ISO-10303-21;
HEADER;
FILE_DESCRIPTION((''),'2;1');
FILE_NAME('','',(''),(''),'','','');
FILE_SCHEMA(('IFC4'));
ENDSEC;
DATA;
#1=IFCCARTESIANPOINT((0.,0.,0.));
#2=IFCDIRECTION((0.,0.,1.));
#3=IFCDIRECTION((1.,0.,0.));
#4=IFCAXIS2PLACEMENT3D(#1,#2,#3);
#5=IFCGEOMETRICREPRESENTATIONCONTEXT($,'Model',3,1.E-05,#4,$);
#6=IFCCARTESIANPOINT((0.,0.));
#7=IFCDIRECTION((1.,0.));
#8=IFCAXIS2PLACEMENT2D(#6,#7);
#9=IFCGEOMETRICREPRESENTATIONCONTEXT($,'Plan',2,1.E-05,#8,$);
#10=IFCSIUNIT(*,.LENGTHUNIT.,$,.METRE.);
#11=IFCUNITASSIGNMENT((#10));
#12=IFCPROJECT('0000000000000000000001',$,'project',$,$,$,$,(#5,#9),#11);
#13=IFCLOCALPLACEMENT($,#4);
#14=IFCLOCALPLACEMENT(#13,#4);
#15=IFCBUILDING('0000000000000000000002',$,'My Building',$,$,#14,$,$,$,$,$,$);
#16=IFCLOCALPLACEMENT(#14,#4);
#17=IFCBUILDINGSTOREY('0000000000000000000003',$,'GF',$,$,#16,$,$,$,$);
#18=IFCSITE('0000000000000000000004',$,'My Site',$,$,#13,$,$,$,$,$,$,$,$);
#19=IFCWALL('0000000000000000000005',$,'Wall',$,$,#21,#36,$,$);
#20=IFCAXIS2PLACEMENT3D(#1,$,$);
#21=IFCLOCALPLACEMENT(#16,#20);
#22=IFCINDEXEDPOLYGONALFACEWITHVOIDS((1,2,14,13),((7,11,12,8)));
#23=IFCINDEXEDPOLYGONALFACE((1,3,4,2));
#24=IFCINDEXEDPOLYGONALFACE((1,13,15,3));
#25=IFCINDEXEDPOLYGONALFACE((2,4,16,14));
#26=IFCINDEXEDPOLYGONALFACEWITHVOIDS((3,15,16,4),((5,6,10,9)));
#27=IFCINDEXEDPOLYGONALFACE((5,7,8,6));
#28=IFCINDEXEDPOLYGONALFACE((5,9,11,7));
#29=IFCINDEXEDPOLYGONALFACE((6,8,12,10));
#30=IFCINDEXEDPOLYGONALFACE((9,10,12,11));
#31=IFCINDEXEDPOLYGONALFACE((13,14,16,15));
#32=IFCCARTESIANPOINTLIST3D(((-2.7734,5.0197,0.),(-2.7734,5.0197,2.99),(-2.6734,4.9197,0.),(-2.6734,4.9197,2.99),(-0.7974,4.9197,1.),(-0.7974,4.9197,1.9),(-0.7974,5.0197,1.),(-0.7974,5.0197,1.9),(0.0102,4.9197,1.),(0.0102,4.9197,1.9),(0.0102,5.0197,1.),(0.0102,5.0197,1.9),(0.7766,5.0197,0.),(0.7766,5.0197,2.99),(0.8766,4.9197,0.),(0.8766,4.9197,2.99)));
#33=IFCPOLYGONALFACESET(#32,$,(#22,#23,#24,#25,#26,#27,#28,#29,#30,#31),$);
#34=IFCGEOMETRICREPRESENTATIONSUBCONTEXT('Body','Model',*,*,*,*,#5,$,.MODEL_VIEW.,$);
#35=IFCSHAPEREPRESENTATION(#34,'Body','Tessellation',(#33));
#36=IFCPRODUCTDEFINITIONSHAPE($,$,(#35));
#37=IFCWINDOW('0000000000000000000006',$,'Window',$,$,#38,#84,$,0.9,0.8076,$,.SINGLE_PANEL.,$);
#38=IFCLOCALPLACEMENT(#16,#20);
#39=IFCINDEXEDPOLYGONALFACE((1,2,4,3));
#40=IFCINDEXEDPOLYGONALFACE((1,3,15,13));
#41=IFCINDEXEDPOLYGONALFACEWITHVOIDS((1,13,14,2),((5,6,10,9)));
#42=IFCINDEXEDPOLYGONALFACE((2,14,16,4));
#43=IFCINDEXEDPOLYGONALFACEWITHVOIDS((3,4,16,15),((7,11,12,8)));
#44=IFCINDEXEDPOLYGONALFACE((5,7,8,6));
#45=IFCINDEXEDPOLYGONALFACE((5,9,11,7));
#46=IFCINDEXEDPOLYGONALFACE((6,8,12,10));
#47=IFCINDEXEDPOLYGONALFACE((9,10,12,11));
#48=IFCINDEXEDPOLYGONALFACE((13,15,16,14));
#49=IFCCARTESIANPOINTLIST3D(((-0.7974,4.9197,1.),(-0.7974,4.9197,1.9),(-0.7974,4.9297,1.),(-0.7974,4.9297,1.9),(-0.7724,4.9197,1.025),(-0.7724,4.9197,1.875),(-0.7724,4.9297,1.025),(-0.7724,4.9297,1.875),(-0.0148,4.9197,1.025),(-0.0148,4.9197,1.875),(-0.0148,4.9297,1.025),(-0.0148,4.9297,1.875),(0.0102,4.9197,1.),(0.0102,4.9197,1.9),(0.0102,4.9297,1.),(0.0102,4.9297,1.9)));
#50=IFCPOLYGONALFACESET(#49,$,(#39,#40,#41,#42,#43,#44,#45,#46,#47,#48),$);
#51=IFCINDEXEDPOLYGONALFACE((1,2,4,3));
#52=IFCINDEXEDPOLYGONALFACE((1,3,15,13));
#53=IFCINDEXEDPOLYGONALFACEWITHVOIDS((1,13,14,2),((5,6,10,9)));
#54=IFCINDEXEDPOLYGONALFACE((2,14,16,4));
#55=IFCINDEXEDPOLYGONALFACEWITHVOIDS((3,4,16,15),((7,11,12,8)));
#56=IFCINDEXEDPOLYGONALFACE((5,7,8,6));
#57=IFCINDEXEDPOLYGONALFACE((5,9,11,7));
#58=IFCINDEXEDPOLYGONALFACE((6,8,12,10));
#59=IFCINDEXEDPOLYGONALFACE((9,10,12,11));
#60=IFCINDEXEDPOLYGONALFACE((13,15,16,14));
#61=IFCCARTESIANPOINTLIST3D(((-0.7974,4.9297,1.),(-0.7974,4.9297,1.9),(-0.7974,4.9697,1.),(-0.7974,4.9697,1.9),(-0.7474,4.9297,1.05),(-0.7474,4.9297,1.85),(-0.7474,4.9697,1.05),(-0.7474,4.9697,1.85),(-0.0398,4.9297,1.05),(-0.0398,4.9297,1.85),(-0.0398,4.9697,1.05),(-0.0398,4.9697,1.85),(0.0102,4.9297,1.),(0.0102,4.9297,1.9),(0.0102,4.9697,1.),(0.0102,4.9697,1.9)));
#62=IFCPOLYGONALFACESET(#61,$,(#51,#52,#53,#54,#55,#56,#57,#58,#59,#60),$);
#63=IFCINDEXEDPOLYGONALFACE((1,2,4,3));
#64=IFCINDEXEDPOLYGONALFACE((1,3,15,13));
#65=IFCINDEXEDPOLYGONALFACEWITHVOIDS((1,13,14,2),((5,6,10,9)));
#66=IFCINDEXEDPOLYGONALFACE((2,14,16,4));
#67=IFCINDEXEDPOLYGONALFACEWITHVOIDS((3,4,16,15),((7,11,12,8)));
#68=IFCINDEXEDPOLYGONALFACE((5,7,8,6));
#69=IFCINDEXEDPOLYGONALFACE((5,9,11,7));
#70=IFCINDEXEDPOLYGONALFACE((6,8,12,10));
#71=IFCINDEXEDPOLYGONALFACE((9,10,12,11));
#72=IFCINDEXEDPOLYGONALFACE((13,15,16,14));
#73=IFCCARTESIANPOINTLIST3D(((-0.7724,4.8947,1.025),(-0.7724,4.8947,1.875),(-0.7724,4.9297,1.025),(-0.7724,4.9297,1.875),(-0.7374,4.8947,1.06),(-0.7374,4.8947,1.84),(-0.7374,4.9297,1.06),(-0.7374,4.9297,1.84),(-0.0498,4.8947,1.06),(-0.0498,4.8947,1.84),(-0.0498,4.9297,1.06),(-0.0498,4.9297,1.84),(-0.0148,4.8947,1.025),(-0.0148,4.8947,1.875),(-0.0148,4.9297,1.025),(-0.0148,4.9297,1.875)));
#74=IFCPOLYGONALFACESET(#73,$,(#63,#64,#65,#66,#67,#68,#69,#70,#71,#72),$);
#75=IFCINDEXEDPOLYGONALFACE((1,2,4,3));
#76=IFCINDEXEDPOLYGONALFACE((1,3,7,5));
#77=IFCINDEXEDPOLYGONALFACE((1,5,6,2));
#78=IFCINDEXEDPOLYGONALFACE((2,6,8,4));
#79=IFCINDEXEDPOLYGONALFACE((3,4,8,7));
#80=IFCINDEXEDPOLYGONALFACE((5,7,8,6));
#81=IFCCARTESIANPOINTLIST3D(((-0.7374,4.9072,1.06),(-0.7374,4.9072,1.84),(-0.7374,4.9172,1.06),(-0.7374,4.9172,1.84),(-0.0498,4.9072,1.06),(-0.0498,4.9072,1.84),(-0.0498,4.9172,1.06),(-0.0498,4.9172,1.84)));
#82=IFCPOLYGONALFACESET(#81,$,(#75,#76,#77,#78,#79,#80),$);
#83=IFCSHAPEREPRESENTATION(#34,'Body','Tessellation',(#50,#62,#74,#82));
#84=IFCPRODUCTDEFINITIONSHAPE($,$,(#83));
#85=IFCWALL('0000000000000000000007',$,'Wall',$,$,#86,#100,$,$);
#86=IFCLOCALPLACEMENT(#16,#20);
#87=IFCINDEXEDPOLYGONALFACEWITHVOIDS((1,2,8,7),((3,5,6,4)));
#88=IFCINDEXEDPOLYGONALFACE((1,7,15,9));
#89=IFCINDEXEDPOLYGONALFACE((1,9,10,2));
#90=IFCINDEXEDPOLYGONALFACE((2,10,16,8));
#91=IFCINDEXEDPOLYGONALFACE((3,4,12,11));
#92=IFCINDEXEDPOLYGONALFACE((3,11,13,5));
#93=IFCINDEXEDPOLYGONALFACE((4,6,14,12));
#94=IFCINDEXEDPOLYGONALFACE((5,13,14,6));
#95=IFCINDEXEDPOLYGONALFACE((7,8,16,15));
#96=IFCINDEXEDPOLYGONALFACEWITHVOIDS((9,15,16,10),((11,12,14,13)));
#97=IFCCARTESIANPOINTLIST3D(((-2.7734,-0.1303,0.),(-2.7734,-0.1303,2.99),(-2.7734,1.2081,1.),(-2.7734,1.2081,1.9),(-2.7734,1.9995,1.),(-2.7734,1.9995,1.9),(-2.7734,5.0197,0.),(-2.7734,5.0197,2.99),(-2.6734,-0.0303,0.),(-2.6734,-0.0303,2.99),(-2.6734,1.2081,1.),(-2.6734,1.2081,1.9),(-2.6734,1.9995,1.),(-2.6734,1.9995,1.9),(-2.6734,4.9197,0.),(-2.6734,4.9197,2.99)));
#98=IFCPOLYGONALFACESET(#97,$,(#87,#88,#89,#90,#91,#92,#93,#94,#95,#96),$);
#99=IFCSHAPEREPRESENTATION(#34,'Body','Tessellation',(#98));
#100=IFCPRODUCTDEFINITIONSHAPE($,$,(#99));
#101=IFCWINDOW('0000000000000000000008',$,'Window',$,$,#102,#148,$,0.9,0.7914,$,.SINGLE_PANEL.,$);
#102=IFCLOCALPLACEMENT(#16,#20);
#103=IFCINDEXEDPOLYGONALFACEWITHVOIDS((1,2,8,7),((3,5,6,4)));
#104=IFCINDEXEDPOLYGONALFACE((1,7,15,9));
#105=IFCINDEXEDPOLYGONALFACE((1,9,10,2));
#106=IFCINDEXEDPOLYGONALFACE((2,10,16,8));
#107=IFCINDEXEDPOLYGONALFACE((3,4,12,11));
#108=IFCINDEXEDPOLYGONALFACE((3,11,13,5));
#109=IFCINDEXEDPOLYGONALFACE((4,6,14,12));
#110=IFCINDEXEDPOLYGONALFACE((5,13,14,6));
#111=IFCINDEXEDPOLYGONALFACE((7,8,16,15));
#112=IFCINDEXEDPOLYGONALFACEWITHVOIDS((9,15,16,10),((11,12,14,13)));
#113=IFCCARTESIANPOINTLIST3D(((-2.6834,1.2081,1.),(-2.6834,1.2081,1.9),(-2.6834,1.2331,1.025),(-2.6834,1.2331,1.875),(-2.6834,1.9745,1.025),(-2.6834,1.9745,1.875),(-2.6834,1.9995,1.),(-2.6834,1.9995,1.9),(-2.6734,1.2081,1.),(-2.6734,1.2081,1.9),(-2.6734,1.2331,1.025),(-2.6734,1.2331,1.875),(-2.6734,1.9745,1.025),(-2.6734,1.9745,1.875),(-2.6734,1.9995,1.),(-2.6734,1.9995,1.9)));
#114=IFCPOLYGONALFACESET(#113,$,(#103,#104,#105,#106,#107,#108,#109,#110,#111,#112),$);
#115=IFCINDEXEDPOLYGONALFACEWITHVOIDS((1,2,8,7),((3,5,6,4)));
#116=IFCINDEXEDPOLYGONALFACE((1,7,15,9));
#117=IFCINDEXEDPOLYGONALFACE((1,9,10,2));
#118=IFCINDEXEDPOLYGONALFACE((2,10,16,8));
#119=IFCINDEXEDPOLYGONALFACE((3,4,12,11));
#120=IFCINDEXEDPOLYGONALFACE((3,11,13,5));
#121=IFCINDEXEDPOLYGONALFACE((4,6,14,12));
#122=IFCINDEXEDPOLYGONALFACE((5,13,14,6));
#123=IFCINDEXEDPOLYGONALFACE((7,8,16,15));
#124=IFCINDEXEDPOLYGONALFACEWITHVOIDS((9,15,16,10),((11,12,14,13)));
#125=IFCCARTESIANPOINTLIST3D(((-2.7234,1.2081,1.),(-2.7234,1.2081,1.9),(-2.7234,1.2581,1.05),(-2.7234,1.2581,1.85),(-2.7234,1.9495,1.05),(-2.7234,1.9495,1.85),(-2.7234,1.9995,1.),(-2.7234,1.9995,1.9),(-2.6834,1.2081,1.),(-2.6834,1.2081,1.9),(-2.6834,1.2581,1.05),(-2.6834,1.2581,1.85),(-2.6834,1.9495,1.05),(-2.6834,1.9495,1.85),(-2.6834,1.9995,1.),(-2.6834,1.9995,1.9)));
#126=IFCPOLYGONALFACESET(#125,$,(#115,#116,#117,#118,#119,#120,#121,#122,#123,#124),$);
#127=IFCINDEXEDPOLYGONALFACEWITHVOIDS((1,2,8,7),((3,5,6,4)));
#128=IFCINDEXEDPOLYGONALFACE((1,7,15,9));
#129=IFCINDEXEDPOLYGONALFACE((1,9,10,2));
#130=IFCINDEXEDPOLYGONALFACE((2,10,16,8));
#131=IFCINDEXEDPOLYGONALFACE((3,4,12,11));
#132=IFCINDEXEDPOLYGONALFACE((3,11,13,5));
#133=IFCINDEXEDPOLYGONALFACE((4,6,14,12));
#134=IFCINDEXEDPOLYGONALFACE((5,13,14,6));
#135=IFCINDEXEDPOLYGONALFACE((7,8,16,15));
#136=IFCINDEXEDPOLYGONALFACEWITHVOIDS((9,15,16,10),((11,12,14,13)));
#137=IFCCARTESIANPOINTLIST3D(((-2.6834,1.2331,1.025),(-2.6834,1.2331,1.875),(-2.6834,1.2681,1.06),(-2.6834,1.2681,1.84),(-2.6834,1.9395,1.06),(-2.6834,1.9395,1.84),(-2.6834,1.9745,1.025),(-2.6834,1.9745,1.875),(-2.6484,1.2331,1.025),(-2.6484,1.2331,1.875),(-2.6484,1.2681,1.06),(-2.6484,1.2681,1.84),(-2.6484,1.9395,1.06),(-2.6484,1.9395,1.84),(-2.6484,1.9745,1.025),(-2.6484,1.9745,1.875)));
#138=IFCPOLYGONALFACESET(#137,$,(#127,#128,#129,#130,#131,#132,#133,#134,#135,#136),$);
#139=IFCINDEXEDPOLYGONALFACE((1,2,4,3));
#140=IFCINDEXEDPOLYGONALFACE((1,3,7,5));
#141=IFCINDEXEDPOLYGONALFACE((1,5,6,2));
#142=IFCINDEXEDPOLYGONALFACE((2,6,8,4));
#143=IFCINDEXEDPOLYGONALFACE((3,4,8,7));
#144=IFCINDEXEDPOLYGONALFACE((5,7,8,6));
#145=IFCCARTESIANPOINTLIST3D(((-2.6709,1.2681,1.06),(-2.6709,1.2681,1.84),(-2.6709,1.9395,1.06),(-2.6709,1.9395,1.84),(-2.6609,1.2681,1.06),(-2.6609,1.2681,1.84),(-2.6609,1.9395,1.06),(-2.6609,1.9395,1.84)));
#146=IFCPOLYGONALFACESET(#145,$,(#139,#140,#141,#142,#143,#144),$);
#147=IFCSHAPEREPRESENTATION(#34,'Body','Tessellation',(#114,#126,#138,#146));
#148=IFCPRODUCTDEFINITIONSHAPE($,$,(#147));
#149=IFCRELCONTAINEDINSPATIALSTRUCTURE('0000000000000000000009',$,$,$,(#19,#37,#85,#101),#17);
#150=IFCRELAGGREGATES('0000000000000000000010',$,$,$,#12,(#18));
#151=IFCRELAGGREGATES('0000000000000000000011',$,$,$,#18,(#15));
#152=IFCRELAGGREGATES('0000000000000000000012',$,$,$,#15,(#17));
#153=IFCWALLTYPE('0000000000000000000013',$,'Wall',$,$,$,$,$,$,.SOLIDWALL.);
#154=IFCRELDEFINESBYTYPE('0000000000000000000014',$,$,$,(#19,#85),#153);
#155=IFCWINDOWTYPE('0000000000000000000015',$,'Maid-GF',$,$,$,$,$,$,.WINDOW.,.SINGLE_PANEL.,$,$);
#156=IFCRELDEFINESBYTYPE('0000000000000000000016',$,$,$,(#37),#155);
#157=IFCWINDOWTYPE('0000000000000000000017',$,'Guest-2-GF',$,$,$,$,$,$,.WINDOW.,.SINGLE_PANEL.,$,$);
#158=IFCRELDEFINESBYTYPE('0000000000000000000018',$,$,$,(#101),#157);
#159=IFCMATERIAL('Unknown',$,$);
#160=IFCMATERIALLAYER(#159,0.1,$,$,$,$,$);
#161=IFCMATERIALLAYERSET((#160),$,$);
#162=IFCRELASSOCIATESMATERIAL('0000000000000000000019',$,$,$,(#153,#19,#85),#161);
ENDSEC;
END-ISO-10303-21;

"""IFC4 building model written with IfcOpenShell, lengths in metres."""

from ifc_helpers import new_model, entity, si_unit, frame, origin_with_axes, origin_2d_with_axis, place, context, subcontext, project, spatial, line, indexed_curve, outline, extrude, shape, source, transform, mapped, material, layer, layer_set, layer_usage, type_object, type_shapes, element, fill, save


model = new_model("IFC4")

# Units and contexts
model_context = context("Model", 3, precision=1e-05, world=origin_with_axes())
plan_context = context("Plan", 2, precision=1e-05, world=origin_2d_with_axis())
body_context_1 = subcontext(model_context, "Body", "Model", "MODEL_VIEW")
body_context_2 = subcontext(plan_context, "Body", "Plan", "PLAN_VIEW")
ifc_project = project(units=[si_unit("LENGTHUNIT", "METRE")], contexts=[model_context, plan_context])

# Site, building, storey
site_placement = place(None, origin_with_axes())
site = spatial("IfcSite", under=ifc_project, at=site_placement, Name="My Site")
building_placement = place(site_placement, origin_with_axes())
building = spatial("IfcBuilding", under=site, at=building_placement, Name="My Building")
storey_placement = place(building_placement, origin_with_axes())
storey = spatial("IfcBuildingStorey", under=building, at=storey_placement, Name="GF")

# Shared definitions
ifc_material_1 = material(Name="Unknown")

# Shared definitions
ifc_layer_1 = layer(ifc_material_1, 0.1)
ifc_layer_set_1 = layer_set([ifc_layer_1])
wall_type = type_object("IfcWallType", Name="Wall", PredefinedType="SOLIDWALL", material=ifc_layer_set_1)

# Walls, openings, windows
ifc_layer_usage_1 = layer_usage(ifc_layer_set_1, "AXIS2", "POSITIVE", 0.0)
wall_1_placement = place(storey_placement, frame((0.7766, 5.0197, 0.0), z_axis=(0.0, 0.0, 1.0), x_axis=(-1.0, 0.0, 0.0)))
wall_1 = element("IfcWall", 1, at=wall_1_placement, inside=storey, type_object=wall_type, material=ifc_layer_usage_1, Name="Wall", context=body_context_1, shape_type="SweptSolid", body=[
    extrude(outline(indexed_curve([(0.0, 0.0), (-0.1, 0.1), (3.45, 0.1), (3.55, 0.0)], segments=[line(1, 2, 3, 4, 1)])), origin_with_axes(), (0.0, 0.0, 1.0), 2.99),
])
shared_shape_1 = source(origin_with_axes(), body_context_1, "Body", "SweptSolid", [
    extrude(outline(indexed_curve([(0.0, 0.0), (0.8076, 0.0), (0.8076, 0.9), (0.0, 0.9)], segments=[line(1, 2, 3, 4, 1)])), frame((0.0, -0.6, 0.0), z_axis=(0.0, -1.0, 0.0), x_axis=(1.0, 0.0, 0.0)), (0.0, 0.0, -1.0), 1.2),
])
opening_1_placement = place(wall_1_placement, frame((0.7664, 0.0, 1.0), z_axis=(0.0, 0.0, 1.0), x_axis=(1.0, 0.0, 0.0)))
opening_1 = element("IfcOpeningElement", 2, at=opening_1_placement, cuts=wall_1, PredefinedType="OPENING", context=body_context_1, shape_type="MappedRepresentation", body=[
    mapped(shared_shape_1, transform((0.0, 0.0, 0.0), x_axis=(1.0, 0.0, 0.0), y_axis=(0.0, 1.0, 0.0), z_axis=(0.0, 0.0, 1.0), scale=1.0)),
])
window_type_1 = type_object("IfcWindowType", Name="Maid-GF", PartitioningType="SINGLE_PANEL", PredefinedType="WINDOW")
shared_shape_2 = source(origin_with_axes(), body_context_1, "Body", "SweptSolid", [
    extrude(outline(indexed_curve([(0.0, 0.0), (0.8076, 0.0), (0.8076, 0.9), (0.0, 0.9)], segments=[line(1, 2, 3, 4, 1)]), holes=[indexed_curve([(0.025, 0.025), (0.7826, 0.025), (0.7826, 0.875), (0.025, 0.875)], segments=[line(1, 2, 3, 4, 1)])]), frame((0.0, 0.09, 0.0), z_axis=(0.0, -1.0, 0.0), x_axis=(1.0, 0.0, 0.0)), (0.0, 0.0, -1.0), 0.01),
    extrude(outline(indexed_curve([(0.0, 0.0), (0.8076, 0.0), (0.8076, 0.9), (0.0, 0.9)], segments=[line(1, 2, 3, 4, 1)]), holes=[indexed_curve([(0.05, 0.05), (0.7576, 0.05), (0.7576, 0.85), (0.05, 0.85)], segments=[line(1, 2, 3, 4, 1)])]), frame((0.0, 0.05, 0.0), z_axis=(0.0, -1.0, 0.0), x_axis=(1.0, 0.0, 0.0)), (0.0, 0.0, -1.0), 0.04),
    extrude(outline(indexed_curve([(0.0, 0.0), (0.7576, 0.0), (0.7576, 0.85), (0.0, 0.85)], segments=[line(1, 2, 3, 4, 1)]), holes=[indexed_curve([(0.035, 0.035), (0.7226, 0.035), (0.7226, 0.815), (0.035, 0.815)], segments=[line(1, 2, 3, 4, 1)])]), frame((0.025, 0.09, 0.025), z_axis=(0.0, -1.0, 0.0), x_axis=(1.0, 0.0, 0.0)), (0.0, 0.0, -1.0), 0.035),
    extrude(outline(indexed_curve([(0.035, 0.035), (0.7226, 0.035), (0.7226, 0.815), (0.035, 0.815)], segments=[line(1, 2, 3, 4, 1)])), frame((0.025, 0.1025, 0.025), z_axis=(0.0, -1.0, 0.0), x_axis=(1.0, 0.0, 0.0)), (0.0, 0.0, -1.0), 0.01),
])
shared_shape_3 = source(origin_with_axes(), body_context_2, "Body", "Curve2D", [
    entity("IfcIndexedPolyCurve", entity("IfcCartesianPointList2D", [[0.05, 0.05], [0.7576, 0.05]])),
    entity("IfcIndexedPolyCurve", entity("IfcCartesianPointList2D", [[0.0, 0.1], [0.025, 0.1], [0.025, 0.09], [0.05, 0.09], [0.05, 0.05], [0.0, 0.05]]), [entity("IfcLineIndex", [1, 2, 3, 4, 5, 6, 1])]),
    entity("IfcIndexedPolyCurve", entity("IfcCartesianPointList2D", [[0.8076, 0.1], [0.7826, 0.1], [0.7826, 0.09], [0.7576, 0.09], [0.7576, 0.05], [0.8076, 0.05]]), [entity("IfcLineIndex", [1, 2, 3, 4, 5, 6, 1])]),
    entity("IfcIndexedPolyCurve", entity("IfcCartesianPointList2D", [[0.025, 0.09], [0.06, 0.09], [0.06, 0.125], [0.025, 0.125]]), [entity("IfcLineIndex", [1, 2, 3, 4, 1])]),
    entity("IfcIndexedPolyCurve", entity("IfcCartesianPointList2D", [[0.7826, 0.09], [0.7476, 0.09], [0.7476, 0.125], [0.7826, 0.125]]), [entity("IfcLineIndex", [1, 2, 3, 4, 1])]),
    entity("IfcIndexedPolyCurve", entity("IfcCartesianPointList2D", [[0.06, 0.09], [0.7476, 0.09]])),
    entity("IfcIndexedPolyCurve", entity("IfcCartesianPointList2D", [[0.06, 0.125], [0.7476, 0.125]])),
    entity("IfcIndexedPolyCurve", entity("IfcCartesianPointList2D", [[0.06, 0.1075], [0.7476, 0.1075]])),
])
type_shapes(window_type_1, [shared_shape_2, shared_shape_3])
window_1_placement = place(opening_1_placement, origin_with_axes())
window_1 = element("IfcWindow", 3, at=window_1_placement, inside=storey, type_object=window_type_1, Name="Window", OverallHeight=0.9, OverallWidth=0.8076, PartitioningType="SINGLE_PANEL", shapes=[
    shape(body_context_1, "Body", "MappedRepresentation", [mapped(shared_shape_2, transform((0.0, 0.0, 0.0), x_axis=(1.0, 0.0, 0.0), y_axis=(0.0, 1.0, 0.0), z_axis=(0.0, 0.0, 1.0), scale=1.0))]),
    shape(body_context_2, "Body", "MappedRepresentation", [mapped(shared_shape_3, transform((0.0, 0.0, 0.0), x_axis=(1.0, 0.0, 0.0), y_axis=(0.0, 1.0, 0.0), z_axis=(0.0, 0.0, 1.0), scale=1.0))]),
])
fill(opening_1, window_1)
ifc_layer_usage_2 = layer_usage(ifc_layer_set_1, "AXIS2", "POSITIVE", 0.0)
wall_2_placement = place(storey_placement, frame((-2.7734, 5.0197, 0.0), z_axis=(0.0, 0.0, 1.0), x_axis=(0.0, -1.0, 0.0)))
wall_2 = element("IfcWall", 4, at=wall_2_placement, inside=storey, type_object=wall_type, material=ifc_layer_usage_2, Name="Wall", context=body_context_1, shape_type="SweptSolid", body=[
    extrude(outline(indexed_curve([(0.0, 0.0), (0.1, 0.1), (5.05, 0.1), (5.15, 0.0)], segments=[line(1, 2, 3, 4, 1)])), origin_with_axes(), (0.0, 0.0, 1.0), 2.99),
])
shared_shape_4 = source(origin_with_axes(), body_context_1, "Body", "SweptSolid", [
    extrude(outline(indexed_curve([(0.0, 0.0), (0.7914, 0.0), (0.7914, 0.9), (0.0, 0.9)], segments=[line(1, 2, 3, 4, 1)])), frame((0.0, -0.6, 0.0), z_axis=(0.0, -1.0, 0.0), x_axis=(1.0, 0.0, 0.0)), (0.0, 0.0, -1.0), 1.2),
])
opening_2_placement = place(wall_2_placement, frame((3.0202, 0.0, 1.0), z_axis=(0.0, 0.0, 1.0), x_axis=(1.0, 0.0, 0.0)))
opening_2 = element("IfcOpeningElement", 5, at=opening_2_placement, cuts=wall_2, PredefinedType="OPENING", context=body_context_1, shape_type="MappedRepresentation", body=[
    mapped(shared_shape_4, transform((0.0, 0.0, 0.0), x_axis=(1.0, 0.0, 0.0), y_axis=(0.0, 1.0, 0.0), z_axis=(0.0, 0.0, 1.0), scale=1.0)),
])
window_type_2 = type_object("IfcWindowType", Name="Guest-2-GF", PartitioningType="SINGLE_PANEL", PredefinedType="WINDOW")
shared_shape_5 = source(origin_with_axes(), body_context_1, "Body", "SweptSolid", [
    extrude(outline(indexed_curve([(0.0, 0.0), (0.7914, 0.0), (0.7914, 0.9), (0.0, 0.9)], segments=[line(1, 2, 3, 4, 1)]), holes=[indexed_curve([(0.025, 0.025), (0.7664, 0.025), (0.7664, 0.875), (0.025, 0.875)], segments=[line(1, 2, 3, 4, 1)])]), frame((0.0, 0.09, 0.0), z_axis=(0.0, -1.0, 0.0), x_axis=(1.0, 0.0, 0.0)), (0.0, 0.0, -1.0), 0.01),
    extrude(outline(indexed_curve([(0.0, 0.0), (0.7914, 0.0), (0.7914, 0.9), (0.0, 0.9)], segments=[line(1, 2, 3, 4, 1)]), holes=[indexed_curve([(0.05, 0.05), (0.7414, 0.05), (0.7414, 0.85), (0.05, 0.85)], segments=[line(1, 2, 3, 4, 1)])]), frame((0.0, 0.05, 0.0), z_axis=(0.0, -1.0, 0.0), x_axis=(1.0, 0.0, 0.0)), (0.0, 0.0, -1.0), 0.04),
    extrude(outline(indexed_curve([(0.0, 0.0), (0.7414, 0.0), (0.7414, 0.85), (0.0, 0.85)], segments=[line(1, 2, 3, 4, 1)]), holes=[indexed_curve([(0.035, 0.035), (0.7064, 0.035), (0.7064, 0.815), (0.035, 0.815)], segments=[line(1, 2, 3, 4, 1)])]), frame((0.025, 0.09, 0.025), z_axis=(0.0, -1.0, 0.0), x_axis=(1.0, 0.0, 0.0)), (0.0, 0.0, -1.0), 0.035),
    extrude(outline(indexed_curve([(0.035, 0.035), (0.7064, 0.035), (0.7064, 0.815), (0.035, 0.815)], segments=[line(1, 2, 3, 4, 1)])), frame((0.025, 0.1025, 0.025), z_axis=(0.0, -1.0, 0.0), x_axis=(1.0, 0.0, 0.0)), (0.0, 0.0, -1.0), 0.01),
])
shared_shape_6 = source(origin_with_axes(), body_context_2, "Body", "Curve2D", [
    entity("IfcIndexedPolyCurve", entity("IfcCartesianPointList2D", [[0.05, 0.05], [0.7414, 0.05]])),
    entity("IfcIndexedPolyCurve", entity("IfcCartesianPointList2D", [[0.0, 0.1], [0.025, 0.1], [0.025, 0.09], [0.05, 0.09], [0.05, 0.05], [0.0, 0.05]]), [entity("IfcLineIndex", [1, 2, 3, 4, 5, 6, 1])]),
    entity("IfcIndexedPolyCurve", entity("IfcCartesianPointList2D", [[0.7914, 0.1], [0.7664, 0.1], [0.7664, 0.09], [0.7414, 0.09], [0.7414, 0.05], [0.7914, 0.05]]), [entity("IfcLineIndex", [1, 2, 3, 4, 5, 6, 1])]),
    entity("IfcIndexedPolyCurve", entity("IfcCartesianPointList2D", [[0.025, 0.09], [0.06, 0.09], [0.06, 0.125], [0.025, 0.125]]), [entity("IfcLineIndex", [1, 2, 3, 4, 1])]),
    entity("IfcIndexedPolyCurve", entity("IfcCartesianPointList2D", [[0.7664, 0.09], [0.7314, 0.09], [0.7314, 0.125], [0.7664, 0.125]]), [entity("IfcLineIndex", [1, 2, 3, 4, 1])]),
    entity("IfcIndexedPolyCurve", entity("IfcCartesianPointList2D", [[0.06, 0.09], [0.7314, 0.09]])),
    entity("IfcIndexedPolyCurve", entity("IfcCartesianPointList2D", [[0.06, 0.125], [0.7314, 0.125]])),
    entity("IfcIndexedPolyCurve", entity("IfcCartesianPointList2D", [[0.06, 0.1075], [0.7314, 0.1075]])),
])
type_shapes(window_type_2, [shared_shape_5, shared_shape_6])
window_2_placement = place(opening_2_placement, frame((0.0, 0.0, 0.0), z_axis=(0.0, 0.0, 1.0), x_axis=(1.0, 0.0, 0.0)))
window_2 = element("IfcWindow", 6, at=window_2_placement, inside=storey, type_object=window_type_2, Name="Window", OverallHeight=0.9, OverallWidth=0.7914, PartitioningType="SINGLE_PANEL", shapes=[
    shape(body_context_1, "Body", "MappedRepresentation", [mapped(shared_shape_5, transform((0.0, 0.0, 0.0), x_axis=(1.0, 0.0, 0.0), y_axis=(0.0, 1.0, 0.0), z_axis=(0.0, 0.0, 1.0), scale=1.0))]),
    shape(body_context_2, "Body", "MappedRepresentation", [mapped(shared_shape_6, transform((0.0, 0.0, 0.0), x_axis=(1.0, 0.0, 0.0), y_axis=(0.0, 1.0, 0.0), z_axis=(0.0, 0.0, 1.0), scale=1.0))]),
])
fill(opening_2, window_2)

save(model, "model.ifc")
